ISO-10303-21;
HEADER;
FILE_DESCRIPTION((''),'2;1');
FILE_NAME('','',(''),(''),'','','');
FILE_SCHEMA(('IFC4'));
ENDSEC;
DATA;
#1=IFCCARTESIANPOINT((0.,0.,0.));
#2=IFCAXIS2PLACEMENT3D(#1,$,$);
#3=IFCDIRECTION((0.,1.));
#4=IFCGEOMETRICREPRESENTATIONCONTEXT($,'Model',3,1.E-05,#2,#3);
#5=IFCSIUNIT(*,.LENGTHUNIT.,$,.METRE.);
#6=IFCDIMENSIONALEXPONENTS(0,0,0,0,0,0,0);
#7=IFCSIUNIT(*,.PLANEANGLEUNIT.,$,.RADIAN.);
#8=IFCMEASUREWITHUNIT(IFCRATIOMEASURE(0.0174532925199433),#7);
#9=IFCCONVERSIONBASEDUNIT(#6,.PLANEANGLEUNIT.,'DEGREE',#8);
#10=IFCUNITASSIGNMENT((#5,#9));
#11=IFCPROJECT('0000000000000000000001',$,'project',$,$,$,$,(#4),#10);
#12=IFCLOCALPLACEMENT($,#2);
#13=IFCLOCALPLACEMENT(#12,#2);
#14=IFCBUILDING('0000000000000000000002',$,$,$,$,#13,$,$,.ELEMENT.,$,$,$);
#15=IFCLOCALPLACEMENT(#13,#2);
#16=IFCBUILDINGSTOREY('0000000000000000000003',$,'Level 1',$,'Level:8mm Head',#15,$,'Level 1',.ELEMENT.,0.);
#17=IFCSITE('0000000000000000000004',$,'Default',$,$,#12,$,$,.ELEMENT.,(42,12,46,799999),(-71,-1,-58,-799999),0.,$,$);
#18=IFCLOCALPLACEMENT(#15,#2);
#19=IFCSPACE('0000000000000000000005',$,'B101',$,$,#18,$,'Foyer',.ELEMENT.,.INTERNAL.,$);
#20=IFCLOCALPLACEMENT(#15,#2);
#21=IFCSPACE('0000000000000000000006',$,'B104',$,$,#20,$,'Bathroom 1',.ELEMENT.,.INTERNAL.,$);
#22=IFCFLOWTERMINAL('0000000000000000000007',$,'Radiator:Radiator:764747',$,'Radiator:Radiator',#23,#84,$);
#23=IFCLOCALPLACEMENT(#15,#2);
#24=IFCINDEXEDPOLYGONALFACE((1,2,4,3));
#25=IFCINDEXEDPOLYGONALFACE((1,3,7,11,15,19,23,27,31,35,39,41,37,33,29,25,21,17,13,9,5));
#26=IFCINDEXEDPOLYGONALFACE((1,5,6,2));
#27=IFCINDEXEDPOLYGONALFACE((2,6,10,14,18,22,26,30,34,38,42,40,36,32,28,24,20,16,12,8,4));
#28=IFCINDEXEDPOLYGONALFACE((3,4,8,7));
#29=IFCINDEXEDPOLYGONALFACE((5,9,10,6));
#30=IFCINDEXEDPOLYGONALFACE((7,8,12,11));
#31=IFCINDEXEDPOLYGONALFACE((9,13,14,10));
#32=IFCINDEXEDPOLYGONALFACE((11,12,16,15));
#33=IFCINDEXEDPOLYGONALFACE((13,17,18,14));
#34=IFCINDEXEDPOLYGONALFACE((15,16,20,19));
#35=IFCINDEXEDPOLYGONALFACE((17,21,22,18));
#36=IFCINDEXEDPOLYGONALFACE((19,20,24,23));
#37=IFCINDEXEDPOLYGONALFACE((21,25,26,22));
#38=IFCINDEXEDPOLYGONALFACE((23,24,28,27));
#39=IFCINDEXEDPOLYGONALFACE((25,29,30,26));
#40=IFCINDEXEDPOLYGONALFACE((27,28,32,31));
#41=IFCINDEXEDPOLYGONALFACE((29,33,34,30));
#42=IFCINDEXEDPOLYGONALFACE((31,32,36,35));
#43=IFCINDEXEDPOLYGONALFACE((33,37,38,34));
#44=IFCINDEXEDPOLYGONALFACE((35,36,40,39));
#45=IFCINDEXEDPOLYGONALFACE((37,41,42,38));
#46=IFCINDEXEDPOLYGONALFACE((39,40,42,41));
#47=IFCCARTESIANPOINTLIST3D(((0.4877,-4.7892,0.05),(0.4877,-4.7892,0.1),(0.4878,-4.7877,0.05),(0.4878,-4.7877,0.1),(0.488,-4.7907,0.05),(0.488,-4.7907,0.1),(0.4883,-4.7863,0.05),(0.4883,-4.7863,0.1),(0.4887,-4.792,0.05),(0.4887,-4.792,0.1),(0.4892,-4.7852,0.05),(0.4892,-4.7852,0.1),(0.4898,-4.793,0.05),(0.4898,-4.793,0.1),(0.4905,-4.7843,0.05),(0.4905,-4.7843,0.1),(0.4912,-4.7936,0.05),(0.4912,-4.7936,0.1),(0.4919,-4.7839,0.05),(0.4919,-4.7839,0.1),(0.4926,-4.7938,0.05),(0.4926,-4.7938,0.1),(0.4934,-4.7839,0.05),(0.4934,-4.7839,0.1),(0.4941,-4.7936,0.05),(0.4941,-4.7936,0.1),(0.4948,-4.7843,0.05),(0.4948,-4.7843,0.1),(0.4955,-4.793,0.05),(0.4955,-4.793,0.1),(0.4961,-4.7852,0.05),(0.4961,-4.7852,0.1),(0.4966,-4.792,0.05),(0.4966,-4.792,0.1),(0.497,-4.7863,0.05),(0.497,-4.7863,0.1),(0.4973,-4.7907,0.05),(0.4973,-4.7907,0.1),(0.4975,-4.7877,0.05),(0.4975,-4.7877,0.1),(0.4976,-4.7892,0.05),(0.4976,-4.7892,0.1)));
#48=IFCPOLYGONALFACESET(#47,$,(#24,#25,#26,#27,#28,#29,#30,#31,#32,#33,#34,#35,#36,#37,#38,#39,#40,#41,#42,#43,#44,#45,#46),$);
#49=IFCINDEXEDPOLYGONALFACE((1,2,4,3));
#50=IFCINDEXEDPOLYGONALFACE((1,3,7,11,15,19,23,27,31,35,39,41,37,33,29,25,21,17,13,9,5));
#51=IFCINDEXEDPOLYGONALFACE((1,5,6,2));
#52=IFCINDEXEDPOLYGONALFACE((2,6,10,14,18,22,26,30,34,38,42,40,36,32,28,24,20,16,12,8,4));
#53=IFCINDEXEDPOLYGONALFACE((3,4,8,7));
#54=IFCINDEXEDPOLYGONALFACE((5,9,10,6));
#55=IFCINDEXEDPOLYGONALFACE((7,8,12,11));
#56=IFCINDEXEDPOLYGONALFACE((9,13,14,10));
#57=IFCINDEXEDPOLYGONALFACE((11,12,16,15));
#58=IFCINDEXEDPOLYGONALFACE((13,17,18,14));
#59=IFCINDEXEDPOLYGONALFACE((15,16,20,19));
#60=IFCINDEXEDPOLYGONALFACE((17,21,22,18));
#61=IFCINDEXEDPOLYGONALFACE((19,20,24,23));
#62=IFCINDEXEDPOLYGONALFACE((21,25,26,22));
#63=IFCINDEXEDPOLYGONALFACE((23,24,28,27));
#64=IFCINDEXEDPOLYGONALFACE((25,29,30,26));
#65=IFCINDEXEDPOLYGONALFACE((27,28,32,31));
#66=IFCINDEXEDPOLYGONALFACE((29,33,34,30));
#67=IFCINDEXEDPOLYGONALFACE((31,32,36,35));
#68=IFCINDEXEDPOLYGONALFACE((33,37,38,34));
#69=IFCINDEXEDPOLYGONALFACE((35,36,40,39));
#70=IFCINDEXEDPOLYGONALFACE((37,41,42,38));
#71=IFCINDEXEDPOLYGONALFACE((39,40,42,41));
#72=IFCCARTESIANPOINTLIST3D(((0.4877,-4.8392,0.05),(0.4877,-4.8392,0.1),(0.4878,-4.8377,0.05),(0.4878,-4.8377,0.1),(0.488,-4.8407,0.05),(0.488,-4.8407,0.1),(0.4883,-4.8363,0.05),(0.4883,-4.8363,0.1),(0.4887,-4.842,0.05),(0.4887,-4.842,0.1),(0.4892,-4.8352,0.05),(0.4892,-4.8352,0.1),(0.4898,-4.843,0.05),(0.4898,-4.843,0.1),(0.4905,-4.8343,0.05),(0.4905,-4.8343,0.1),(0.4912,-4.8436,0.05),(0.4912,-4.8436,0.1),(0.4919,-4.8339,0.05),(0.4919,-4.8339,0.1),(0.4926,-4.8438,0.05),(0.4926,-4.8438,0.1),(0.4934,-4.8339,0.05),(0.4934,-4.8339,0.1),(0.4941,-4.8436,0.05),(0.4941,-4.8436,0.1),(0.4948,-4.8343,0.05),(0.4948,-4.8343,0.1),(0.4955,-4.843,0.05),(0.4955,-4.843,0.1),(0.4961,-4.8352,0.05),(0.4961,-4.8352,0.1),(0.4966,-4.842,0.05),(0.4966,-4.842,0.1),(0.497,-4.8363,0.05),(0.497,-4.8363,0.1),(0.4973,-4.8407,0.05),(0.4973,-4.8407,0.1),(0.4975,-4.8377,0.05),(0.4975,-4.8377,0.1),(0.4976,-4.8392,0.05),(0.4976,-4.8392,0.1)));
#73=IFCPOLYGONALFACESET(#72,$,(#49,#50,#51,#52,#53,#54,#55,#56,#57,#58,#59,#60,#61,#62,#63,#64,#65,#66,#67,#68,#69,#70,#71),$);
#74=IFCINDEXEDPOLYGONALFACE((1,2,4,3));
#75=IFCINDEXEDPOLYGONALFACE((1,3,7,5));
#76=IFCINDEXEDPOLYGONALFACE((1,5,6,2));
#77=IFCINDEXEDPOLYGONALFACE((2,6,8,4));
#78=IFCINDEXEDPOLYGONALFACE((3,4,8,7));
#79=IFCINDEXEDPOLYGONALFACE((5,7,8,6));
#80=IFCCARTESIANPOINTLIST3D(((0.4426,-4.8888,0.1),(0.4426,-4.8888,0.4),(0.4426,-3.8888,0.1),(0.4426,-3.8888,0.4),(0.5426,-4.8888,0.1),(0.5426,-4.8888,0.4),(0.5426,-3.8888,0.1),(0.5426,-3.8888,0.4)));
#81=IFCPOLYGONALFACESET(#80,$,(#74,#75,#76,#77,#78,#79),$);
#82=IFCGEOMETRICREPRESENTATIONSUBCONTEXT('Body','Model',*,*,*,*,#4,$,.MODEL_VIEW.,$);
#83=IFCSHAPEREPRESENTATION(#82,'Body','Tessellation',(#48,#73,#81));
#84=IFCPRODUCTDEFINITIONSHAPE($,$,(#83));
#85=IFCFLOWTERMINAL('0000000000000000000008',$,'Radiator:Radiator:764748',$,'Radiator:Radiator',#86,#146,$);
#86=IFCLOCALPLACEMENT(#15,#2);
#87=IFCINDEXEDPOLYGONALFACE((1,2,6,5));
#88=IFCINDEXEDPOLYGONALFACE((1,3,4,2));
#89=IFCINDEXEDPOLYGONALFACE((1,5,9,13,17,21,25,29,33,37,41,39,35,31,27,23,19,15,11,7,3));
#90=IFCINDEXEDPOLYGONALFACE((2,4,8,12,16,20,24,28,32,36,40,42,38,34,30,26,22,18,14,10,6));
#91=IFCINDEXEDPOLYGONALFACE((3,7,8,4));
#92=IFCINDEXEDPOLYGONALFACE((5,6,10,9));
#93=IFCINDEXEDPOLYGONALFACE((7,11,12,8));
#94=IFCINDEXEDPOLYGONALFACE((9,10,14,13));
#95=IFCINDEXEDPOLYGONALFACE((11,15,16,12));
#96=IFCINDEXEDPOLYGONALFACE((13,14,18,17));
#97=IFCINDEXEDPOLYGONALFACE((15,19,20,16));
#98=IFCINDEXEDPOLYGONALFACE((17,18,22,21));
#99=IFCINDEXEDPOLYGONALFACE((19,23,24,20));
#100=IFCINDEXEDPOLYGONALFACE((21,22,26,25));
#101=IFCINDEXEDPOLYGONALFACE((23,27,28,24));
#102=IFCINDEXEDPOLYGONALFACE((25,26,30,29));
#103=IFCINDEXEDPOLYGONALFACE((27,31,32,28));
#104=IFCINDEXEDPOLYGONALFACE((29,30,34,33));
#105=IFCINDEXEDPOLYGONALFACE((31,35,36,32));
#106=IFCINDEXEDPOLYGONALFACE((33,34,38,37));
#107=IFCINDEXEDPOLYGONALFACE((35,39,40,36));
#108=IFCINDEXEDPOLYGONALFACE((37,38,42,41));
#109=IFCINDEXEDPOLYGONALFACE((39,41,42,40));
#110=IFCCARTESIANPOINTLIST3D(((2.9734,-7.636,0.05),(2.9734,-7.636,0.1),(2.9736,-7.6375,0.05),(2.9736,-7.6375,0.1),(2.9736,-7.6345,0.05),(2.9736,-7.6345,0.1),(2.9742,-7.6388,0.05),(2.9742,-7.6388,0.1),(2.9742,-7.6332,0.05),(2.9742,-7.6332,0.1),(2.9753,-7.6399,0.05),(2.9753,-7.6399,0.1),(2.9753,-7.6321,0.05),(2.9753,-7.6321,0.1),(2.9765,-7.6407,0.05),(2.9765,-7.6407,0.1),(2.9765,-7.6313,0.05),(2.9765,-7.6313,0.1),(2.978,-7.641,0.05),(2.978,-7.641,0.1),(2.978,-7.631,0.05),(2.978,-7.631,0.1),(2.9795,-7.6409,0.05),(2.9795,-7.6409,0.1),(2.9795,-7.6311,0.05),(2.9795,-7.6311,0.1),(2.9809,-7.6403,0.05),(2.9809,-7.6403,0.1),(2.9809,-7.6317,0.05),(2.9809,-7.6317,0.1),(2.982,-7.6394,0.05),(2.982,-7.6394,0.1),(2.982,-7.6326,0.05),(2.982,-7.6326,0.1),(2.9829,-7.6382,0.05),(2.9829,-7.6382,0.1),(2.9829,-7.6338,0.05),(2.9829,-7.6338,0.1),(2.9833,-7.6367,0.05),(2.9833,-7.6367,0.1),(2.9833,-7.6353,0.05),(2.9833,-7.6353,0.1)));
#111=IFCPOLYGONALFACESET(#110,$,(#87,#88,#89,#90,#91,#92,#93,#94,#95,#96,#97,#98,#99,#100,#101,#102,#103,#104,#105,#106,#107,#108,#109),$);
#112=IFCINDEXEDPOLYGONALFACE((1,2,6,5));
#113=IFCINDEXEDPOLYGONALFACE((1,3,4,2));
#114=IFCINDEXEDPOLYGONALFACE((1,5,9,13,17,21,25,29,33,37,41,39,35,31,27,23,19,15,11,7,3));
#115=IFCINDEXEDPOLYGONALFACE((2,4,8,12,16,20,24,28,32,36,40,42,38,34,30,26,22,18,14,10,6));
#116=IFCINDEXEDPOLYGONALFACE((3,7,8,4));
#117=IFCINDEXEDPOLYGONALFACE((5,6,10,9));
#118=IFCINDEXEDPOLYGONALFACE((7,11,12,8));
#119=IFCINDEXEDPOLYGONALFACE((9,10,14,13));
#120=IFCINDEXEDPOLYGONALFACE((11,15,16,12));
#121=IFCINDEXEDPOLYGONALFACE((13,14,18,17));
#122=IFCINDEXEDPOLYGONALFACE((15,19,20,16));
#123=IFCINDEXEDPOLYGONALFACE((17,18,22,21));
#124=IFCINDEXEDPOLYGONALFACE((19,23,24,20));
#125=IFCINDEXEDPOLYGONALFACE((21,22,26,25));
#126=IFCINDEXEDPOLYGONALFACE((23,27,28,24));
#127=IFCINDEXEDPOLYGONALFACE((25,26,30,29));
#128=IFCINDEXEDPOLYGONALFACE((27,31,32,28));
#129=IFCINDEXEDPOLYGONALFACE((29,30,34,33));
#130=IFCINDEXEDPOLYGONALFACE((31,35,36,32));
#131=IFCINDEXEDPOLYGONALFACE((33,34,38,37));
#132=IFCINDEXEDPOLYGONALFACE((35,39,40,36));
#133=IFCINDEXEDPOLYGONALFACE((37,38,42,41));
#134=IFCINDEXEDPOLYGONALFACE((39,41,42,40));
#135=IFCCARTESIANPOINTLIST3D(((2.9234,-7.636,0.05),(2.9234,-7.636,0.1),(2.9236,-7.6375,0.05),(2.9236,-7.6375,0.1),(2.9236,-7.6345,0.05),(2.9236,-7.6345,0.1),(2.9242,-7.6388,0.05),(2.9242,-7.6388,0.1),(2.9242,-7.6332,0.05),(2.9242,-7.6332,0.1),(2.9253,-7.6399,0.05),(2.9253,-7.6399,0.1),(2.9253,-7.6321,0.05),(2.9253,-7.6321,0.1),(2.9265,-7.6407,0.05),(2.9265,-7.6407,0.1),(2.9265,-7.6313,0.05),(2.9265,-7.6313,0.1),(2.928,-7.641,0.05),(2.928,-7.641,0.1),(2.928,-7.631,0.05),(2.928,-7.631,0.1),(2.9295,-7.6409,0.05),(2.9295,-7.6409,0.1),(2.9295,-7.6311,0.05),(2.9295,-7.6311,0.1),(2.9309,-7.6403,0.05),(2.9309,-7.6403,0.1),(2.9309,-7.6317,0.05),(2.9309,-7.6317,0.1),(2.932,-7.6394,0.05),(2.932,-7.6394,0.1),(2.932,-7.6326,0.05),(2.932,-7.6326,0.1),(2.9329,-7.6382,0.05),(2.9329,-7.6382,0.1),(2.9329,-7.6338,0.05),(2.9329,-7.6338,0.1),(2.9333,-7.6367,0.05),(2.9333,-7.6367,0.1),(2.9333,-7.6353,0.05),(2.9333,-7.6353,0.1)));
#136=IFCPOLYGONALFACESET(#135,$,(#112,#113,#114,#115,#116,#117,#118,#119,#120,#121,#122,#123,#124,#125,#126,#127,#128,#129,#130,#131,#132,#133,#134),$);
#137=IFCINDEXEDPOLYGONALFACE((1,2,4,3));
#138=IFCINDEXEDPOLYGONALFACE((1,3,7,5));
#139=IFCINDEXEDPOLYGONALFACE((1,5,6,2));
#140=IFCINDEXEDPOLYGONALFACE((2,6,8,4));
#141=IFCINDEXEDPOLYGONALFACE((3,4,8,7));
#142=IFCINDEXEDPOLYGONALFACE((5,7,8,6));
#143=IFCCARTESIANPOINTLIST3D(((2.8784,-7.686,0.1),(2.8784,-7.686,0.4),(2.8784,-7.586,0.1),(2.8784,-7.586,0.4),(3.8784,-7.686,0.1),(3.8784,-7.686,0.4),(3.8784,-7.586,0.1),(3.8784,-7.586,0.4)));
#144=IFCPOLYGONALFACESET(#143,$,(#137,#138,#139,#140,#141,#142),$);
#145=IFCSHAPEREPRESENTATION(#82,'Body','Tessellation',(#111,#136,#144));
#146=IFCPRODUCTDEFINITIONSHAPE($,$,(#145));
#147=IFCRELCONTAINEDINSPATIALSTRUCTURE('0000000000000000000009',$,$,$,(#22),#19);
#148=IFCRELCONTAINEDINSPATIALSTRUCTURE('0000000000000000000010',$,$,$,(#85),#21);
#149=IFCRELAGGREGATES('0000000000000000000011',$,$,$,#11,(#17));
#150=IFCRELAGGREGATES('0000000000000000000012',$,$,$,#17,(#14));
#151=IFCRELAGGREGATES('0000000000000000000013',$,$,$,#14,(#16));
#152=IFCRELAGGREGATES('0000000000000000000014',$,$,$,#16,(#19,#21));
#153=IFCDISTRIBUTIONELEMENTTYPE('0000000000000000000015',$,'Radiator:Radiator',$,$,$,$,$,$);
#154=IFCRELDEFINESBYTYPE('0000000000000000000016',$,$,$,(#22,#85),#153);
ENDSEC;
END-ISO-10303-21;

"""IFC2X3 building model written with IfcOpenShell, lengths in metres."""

from ifc_helpers import new_model, entity, si_unit, converted_unit, direction, frame, frame_2d, origin, origin_2d_with_axis, place, context, subcontext, project, spatial, rectangle, circle, extrude, source, transform, mapped, type_object, type_shapes, element, save


model = new_model("IFC2X3")

# Units and contexts
model_context = context("Model", 3, precision=1e-05, world=origin(), true_north=direction((0.0, 1.0)))
body_context = subcontext(model_context, "Body", "Model", "MODEL_VIEW")
ifc_project = project(units=[si_unit("LENGTHUNIT", "METRE"), converted_unit("PLANEANGLEUNIT", "DEGREE", entity("IfcRatioMeasure", 0.0174532925199433), si_unit("PLANEANGLEUNIT", "RADIAN"), dimensions=[0, 0, 0, 0, 0, 0, 0])], contexts=[model_context])

# Site, building, storey
site_placement = place(None, origin())
site = spatial("IfcSite", under=ifc_project, at=site_placement, Name="Default", CompositionType="ELEMENT", RefLatitude=(42, 12, 46, 799999), RefLongitude=(-71, -1, -58, -799999), RefElevation=0.0)
building_placement = place(site_placement, origin())
building = spatial("IfcBuilding", under=site, at=building_placement, CompositionType="ELEMENT")
storey_placement = place(building_placement, origin())
storey = spatial("IfcBuildingStorey", under=building, at=storey_placement, Name="Level 1", ObjectType="Level:8mm Head", LongName="Level 1", CompositionType="ELEMENT", Elevation=0.0)

# Shared definitions
distribution_element_type_1 = type_object("IfcDistributionElementType", Name="Radiator:Radiator")
shared_shape_1 = source(origin(), body_context, "Body", "SweptSolid", [
    extrude(circle(Radius=0.005, at=frame_2d((0.0, 0.0), x_axis=(1.0, 0.0))), frame((0.4, 0.0, -0.05)), (0.0, 0.0, 1.0), 0.05),
    extrude(circle(Radius=0.005, at=frame_2d((0.0, 0.0), x_axis=(1.0, 0.0))), frame((0.45, 0.0, -0.05)), (0.0, 0.0, 1.0), 0.05),
    extrude(rectangle(XDim=1.0, YDim=0.1, at=origin_2d_with_axis()), frame((0.0, 0.0, 0.0), z_axis=(0.0, 0.0, 1.0), x_axis=(-1.0, 0.0, 0.0)), (0.0, 0.0, 1.0), 0.3),
])
type_shapes(distribution_element_type_1, [shared_shape_1])

# Shared definitions
space_1_placement = place(storey_placement, origin())
space_1 = spatial("IfcSpace", under=storey, at=space_1_placement, Name="B101", LongName="Foyer", CompositionType="ELEMENT", InteriorOrExteriorSpace="INTERNAL")

# Flow terminal
flow_terminal_1_placement = place(space_1_placement, frame((0.4926, -4.3888, 0.1), z_axis=(0.0, 0.0, 1.0), x_axis=(0.0, -1.0, 0.0)))
element("IfcFlowTerminal", 1, at=flow_terminal_1_placement, inside=space_1, type_object=distribution_element_type_1, Name="Radiator:Radiator:764747", ObjectType="Radiator:Radiator", context=body_context, shape_type="MappedRepresentation", body=[
    mapped(shared_shape_1, transform((0.0, 0.0, 0.0), scale=1.0)),
])

# Shared definitions
space_2_placement = place(storey_placement, origin())
space_2 = spatial("IfcSpace", under=storey, at=space_2_placement, Name="B104", LongName="Bathroom 1", CompositionType="ELEMENT", InteriorOrExteriorSpace="INTERNAL")

# Flow terminal
flow_terminal_2_placement = place(space_2_placement, frame((3.3784, -7.636, 0.1), z_axis=(0.0, 0.0, 1.0), x_axis=(-1.0, 0.0, 0.0)))
element("IfcFlowTerminal", 2, at=flow_terminal_2_placement, inside=space_2, type_object=distribution_element_type_1, Name="Radiator:Radiator:764748", ObjectType="Radiator:Radiator", context=body_context, shape_type="MappedRepresentation", body=[
    mapped(shared_shape_1, transform((0.0, 0.0, 0.0), scale=1.0)),
])

save(model, "model.ifc")
